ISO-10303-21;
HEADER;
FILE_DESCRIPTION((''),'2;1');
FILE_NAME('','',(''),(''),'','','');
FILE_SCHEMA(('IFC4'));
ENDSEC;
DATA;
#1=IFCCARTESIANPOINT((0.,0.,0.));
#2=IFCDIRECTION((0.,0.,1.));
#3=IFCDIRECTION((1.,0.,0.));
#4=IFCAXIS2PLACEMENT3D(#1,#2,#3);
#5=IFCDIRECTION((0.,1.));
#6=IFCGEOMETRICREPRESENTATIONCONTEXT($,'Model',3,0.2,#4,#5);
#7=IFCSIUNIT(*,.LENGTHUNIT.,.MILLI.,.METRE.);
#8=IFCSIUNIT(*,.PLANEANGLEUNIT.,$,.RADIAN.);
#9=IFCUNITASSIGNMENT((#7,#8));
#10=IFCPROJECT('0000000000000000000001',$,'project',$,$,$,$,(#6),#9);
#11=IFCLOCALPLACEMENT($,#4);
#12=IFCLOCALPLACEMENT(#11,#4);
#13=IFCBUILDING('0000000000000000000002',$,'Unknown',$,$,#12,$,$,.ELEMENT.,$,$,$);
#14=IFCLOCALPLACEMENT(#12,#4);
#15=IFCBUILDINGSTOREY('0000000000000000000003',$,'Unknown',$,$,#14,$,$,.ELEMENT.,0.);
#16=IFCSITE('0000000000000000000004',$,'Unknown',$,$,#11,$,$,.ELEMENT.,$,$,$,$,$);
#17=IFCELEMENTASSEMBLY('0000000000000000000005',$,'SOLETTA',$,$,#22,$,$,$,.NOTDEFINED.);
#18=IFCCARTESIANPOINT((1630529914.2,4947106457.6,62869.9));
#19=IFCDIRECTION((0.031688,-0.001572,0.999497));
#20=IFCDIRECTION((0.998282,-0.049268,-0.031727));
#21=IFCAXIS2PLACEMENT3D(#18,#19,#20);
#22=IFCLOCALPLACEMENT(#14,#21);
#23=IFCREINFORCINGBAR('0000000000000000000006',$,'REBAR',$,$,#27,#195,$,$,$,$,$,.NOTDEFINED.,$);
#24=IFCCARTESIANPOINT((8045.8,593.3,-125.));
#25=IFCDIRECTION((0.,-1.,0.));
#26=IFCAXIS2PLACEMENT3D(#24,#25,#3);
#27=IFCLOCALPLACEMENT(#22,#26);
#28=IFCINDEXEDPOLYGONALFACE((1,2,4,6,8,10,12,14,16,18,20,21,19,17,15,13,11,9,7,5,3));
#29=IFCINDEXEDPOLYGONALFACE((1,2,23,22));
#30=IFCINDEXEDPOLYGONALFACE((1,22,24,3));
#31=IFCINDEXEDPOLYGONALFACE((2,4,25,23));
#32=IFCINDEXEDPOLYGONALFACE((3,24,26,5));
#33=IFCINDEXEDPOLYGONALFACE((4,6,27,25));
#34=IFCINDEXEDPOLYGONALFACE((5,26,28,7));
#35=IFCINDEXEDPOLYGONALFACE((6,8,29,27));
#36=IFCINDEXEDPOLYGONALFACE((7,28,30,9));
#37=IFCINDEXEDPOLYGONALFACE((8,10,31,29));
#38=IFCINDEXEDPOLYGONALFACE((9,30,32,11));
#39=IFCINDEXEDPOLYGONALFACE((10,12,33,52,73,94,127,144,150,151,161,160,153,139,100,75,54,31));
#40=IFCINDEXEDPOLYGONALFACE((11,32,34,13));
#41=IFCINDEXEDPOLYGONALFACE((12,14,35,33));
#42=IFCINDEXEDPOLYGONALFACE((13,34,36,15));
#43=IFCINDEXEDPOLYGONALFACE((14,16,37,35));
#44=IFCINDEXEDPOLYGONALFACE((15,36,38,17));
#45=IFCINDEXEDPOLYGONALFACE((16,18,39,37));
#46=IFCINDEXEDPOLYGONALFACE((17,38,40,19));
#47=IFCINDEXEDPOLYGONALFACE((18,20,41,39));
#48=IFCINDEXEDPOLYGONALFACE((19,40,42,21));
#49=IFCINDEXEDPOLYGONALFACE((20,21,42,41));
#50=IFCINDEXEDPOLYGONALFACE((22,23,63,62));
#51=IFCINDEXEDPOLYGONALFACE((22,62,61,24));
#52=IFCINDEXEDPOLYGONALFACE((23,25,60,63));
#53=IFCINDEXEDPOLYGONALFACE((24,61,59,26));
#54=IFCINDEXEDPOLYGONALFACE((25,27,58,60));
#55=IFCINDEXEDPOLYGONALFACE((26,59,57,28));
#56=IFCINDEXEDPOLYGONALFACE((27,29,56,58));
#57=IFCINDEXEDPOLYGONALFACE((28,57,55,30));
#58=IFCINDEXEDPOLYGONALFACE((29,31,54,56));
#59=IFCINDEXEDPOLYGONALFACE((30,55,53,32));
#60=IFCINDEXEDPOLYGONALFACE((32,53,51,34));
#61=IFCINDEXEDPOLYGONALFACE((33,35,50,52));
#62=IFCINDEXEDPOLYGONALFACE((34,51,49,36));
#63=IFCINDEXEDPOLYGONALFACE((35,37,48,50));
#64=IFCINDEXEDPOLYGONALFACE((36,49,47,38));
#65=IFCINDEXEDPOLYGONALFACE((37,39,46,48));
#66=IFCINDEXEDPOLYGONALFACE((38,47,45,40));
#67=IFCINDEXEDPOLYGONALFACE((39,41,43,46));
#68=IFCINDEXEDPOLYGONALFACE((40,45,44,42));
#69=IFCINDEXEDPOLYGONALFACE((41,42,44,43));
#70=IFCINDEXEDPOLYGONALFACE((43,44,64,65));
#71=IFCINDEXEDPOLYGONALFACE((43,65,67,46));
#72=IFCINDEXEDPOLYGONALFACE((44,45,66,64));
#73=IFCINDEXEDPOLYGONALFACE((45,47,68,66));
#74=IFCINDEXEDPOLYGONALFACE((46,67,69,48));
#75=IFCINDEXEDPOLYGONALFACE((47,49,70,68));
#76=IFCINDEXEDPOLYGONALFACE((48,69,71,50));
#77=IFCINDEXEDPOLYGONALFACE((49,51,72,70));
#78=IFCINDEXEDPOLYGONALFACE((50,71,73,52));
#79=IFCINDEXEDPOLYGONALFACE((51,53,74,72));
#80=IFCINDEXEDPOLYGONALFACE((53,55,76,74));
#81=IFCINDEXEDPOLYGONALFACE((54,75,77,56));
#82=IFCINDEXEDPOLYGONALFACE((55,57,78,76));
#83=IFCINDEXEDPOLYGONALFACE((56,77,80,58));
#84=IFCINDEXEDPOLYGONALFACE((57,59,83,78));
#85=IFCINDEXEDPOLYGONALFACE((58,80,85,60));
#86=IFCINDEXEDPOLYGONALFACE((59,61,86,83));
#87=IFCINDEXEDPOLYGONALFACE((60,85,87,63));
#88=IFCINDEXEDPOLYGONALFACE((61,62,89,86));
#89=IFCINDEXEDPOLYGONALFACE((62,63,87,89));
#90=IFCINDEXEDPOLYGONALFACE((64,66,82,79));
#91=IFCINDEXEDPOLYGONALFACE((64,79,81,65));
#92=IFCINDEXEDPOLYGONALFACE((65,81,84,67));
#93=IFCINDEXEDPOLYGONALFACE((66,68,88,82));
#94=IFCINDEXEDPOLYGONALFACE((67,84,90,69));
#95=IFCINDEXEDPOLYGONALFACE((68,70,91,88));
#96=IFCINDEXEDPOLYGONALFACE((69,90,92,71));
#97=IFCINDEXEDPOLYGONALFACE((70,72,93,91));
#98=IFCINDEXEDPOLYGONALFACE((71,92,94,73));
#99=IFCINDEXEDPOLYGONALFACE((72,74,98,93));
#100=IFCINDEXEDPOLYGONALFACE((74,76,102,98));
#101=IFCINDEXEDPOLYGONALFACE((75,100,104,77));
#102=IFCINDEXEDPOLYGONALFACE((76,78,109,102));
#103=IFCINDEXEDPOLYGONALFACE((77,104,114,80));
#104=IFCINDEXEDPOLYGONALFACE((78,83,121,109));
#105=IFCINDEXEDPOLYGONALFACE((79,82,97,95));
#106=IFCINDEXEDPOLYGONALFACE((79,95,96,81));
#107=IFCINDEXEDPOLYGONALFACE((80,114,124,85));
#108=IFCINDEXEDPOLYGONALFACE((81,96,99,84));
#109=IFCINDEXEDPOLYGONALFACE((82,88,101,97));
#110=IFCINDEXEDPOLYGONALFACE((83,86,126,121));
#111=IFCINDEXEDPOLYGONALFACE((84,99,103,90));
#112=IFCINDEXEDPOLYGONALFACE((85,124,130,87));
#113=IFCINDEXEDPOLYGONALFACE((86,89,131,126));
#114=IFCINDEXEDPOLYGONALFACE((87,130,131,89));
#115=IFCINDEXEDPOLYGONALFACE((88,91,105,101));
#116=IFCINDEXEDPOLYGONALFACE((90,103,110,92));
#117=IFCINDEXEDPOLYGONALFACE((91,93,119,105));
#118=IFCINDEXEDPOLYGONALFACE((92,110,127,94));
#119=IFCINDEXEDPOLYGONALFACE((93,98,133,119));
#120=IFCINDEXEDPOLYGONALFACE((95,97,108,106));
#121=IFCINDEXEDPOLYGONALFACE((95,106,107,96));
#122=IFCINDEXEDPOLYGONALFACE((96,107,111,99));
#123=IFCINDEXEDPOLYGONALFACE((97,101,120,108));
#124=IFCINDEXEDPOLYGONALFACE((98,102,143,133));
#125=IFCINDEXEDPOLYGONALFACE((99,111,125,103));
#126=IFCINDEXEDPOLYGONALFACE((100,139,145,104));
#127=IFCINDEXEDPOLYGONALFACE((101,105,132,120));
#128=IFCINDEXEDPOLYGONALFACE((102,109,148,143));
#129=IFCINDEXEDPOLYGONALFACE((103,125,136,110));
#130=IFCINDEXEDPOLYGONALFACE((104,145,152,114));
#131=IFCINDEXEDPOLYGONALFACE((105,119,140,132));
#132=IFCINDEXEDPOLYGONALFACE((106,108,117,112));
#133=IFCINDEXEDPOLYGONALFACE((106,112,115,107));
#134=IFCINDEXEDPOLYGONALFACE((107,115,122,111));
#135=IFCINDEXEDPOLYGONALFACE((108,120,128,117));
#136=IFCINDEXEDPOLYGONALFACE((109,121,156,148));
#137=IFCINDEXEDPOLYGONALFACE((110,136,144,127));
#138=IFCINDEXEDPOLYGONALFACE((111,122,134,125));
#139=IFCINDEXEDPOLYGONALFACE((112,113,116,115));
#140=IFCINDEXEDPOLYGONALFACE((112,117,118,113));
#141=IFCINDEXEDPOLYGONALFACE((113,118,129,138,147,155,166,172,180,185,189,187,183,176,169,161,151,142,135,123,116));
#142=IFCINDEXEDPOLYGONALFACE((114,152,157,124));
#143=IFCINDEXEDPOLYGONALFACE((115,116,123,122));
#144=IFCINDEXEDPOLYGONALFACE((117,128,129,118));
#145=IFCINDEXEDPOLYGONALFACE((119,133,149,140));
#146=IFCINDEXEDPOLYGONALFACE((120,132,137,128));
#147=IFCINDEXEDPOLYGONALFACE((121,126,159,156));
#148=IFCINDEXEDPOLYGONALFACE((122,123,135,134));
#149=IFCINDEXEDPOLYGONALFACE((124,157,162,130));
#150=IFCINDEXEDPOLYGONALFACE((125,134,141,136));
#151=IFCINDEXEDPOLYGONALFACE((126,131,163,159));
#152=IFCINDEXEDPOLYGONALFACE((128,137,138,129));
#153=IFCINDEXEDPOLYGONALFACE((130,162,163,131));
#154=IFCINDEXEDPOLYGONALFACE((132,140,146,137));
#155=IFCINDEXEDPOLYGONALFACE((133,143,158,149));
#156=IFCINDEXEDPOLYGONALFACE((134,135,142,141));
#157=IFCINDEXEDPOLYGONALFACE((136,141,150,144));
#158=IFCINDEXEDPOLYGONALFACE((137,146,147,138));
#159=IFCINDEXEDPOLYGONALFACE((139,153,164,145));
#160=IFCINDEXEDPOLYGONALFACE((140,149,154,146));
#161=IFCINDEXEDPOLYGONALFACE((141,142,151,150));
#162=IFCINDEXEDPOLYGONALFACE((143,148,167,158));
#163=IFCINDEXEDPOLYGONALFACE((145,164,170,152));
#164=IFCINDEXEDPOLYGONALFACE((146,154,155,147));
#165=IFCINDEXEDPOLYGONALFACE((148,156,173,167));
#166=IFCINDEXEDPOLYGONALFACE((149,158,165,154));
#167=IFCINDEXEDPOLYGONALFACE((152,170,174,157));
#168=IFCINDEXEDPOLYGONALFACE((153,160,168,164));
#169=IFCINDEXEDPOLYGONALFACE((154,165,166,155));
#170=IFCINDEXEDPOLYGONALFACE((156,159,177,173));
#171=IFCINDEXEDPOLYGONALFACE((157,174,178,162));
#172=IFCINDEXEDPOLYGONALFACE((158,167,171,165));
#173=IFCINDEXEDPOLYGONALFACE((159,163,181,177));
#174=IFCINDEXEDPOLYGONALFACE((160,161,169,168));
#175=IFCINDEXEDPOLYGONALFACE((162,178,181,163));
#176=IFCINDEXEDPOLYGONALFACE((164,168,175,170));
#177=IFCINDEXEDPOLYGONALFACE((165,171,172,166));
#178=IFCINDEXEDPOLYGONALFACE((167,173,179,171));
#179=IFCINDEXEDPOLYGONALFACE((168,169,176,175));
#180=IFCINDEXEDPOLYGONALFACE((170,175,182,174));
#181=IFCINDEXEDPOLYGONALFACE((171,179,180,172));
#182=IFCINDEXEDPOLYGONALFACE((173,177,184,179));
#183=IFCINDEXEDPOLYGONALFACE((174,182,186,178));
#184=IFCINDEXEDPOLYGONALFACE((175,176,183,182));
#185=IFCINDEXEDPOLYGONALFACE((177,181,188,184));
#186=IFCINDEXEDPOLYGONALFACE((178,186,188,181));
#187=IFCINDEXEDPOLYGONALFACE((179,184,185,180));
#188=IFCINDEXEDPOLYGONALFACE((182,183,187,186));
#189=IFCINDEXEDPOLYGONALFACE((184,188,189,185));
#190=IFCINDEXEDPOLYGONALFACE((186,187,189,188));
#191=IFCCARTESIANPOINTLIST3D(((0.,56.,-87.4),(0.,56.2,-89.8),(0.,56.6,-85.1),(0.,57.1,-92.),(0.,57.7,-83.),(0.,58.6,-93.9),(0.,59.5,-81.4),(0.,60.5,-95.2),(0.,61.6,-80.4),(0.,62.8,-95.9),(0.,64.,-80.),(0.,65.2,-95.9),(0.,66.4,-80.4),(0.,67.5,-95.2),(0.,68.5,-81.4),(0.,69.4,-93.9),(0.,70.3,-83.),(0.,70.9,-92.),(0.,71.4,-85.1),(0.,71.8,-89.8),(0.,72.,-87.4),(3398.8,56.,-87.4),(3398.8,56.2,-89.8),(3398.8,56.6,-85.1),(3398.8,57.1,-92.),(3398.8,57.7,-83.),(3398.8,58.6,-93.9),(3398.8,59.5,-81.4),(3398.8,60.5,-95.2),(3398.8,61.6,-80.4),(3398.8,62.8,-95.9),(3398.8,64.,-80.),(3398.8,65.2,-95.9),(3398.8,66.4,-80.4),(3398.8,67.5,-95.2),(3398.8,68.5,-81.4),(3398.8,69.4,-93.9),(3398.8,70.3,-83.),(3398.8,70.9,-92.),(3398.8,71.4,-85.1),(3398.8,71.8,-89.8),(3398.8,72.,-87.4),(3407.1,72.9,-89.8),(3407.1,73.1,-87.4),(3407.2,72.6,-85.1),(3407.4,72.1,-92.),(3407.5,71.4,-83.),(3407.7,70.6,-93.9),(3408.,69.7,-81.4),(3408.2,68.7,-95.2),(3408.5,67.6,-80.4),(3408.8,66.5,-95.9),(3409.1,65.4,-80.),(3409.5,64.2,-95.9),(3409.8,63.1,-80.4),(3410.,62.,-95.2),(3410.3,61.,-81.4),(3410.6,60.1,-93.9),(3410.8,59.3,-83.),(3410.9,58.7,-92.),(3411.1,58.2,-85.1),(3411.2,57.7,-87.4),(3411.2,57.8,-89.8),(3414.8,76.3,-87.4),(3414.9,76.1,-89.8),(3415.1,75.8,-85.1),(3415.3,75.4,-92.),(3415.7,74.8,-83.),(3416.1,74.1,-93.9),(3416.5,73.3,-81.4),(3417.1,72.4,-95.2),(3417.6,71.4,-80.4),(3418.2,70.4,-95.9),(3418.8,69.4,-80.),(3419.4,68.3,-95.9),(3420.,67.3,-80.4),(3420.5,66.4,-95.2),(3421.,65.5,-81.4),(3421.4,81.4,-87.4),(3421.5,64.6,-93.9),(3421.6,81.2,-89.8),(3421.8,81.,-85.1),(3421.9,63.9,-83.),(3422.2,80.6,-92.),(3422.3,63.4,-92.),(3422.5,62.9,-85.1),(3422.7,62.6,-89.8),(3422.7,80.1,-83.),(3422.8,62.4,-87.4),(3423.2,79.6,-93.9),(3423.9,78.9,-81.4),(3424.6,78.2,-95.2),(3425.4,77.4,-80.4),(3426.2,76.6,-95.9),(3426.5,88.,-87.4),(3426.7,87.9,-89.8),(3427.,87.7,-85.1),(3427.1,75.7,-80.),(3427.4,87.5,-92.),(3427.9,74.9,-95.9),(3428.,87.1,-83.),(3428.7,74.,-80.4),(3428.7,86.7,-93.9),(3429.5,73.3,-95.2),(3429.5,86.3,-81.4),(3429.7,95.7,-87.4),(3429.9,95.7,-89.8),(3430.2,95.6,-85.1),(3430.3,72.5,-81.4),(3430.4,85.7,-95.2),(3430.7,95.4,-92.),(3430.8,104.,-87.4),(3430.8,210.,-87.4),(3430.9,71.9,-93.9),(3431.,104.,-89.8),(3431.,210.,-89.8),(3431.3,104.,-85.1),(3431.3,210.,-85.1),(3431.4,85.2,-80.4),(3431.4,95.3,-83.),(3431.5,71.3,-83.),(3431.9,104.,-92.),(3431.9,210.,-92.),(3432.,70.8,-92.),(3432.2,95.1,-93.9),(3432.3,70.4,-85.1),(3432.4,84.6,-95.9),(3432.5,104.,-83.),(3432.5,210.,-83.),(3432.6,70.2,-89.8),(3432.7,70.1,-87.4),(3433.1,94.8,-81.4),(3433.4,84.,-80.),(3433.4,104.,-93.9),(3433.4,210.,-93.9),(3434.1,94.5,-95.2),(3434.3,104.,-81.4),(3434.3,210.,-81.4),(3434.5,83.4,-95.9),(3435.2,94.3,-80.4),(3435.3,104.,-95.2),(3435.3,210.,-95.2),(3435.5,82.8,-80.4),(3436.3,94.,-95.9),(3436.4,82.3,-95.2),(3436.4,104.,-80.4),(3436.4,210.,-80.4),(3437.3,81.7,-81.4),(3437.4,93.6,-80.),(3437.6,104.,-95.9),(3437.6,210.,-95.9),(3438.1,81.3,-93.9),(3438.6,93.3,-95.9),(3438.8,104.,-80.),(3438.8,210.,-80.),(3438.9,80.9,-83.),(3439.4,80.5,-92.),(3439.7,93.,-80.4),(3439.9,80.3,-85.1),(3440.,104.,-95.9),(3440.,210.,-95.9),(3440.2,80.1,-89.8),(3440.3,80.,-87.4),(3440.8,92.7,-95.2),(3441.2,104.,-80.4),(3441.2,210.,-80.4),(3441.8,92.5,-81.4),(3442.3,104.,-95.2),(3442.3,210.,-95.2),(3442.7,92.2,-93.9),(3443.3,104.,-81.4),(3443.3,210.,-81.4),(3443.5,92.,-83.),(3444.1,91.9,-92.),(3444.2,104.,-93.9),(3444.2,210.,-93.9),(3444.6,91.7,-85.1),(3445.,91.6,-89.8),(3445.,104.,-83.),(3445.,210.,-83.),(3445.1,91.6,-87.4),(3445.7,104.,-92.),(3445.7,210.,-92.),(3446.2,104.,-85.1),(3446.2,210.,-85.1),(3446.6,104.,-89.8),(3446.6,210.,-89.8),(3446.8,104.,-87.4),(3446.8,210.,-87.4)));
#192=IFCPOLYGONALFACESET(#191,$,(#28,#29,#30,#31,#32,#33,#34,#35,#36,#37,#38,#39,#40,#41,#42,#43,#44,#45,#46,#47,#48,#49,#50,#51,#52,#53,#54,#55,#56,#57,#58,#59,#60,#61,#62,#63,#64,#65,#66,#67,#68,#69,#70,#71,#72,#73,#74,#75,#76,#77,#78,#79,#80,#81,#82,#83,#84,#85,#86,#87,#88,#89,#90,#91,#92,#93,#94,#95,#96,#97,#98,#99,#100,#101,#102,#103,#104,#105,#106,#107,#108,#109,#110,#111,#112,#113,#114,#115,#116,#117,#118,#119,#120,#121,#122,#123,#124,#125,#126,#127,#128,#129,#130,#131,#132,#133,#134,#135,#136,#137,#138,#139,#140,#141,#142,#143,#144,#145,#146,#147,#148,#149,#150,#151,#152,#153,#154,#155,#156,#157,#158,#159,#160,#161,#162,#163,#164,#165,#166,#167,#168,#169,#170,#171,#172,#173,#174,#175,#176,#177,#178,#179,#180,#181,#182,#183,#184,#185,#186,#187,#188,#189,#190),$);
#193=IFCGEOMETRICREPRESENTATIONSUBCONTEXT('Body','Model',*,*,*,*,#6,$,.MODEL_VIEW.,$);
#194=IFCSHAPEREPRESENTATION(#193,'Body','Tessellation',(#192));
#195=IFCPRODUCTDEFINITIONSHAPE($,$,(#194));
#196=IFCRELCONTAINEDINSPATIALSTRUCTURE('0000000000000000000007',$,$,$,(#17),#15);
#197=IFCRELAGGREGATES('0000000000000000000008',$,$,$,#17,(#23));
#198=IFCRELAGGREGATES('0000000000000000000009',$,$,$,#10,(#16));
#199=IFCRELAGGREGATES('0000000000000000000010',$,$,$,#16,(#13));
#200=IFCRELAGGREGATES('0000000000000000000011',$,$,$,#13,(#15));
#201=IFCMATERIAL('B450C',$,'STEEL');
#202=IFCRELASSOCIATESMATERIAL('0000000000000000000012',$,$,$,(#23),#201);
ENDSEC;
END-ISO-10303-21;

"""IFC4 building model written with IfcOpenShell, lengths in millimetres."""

from ifc_helpers import new_model, entity, si_unit, direction, frame, origin_with_axes, place, context, subcontext, project, spatial, material, element, aggregate, save


model = new_model("IFC4")

# Units and contexts
model_context = context("Model", 3, precision=0.2, world=origin_with_axes(), true_north=direction((0.0, 1.0)))
body_context = subcontext(model_context, "Body", "Model", "MODEL_VIEW")
ifc_project = project(units=[si_unit("LENGTHUNIT", "METRE", prefix="MILLI"), si_unit("PLANEANGLEUNIT", "RADIAN")], contexts=[model_context])

# Site, building, storey
site_placement = place(None, origin_with_axes())
site = spatial("IfcSite", under=ifc_project, at=site_placement, Name="Unknown", CompositionType="ELEMENT")
building_placement = place(site_placement, origin_with_axes())
building = spatial("IfcBuilding", under=site, at=building_placement, Name="Unknown", CompositionType="ELEMENT")
storey_placement = place(building_placement, origin_with_axes())
storey = spatial("IfcBuildingStorey", under=building, at=storey_placement, Name="Unknown", CompositionType="ELEMENT", Elevation=0.0)

# Element assembly, reinforcing bar
ifc_material = material(Name="B450C", Category="STEEL")
assembly_1_placement = place(storey_placement, frame((1630529914.2, 4947106457.6, 62869.9), z_axis=(0.031688, -0.001572, 0.999497), x_axis=(0.998282, -0.049268, -0.031727)))
assembly_1 = element("IfcElementAssembly", 1, at=assembly_1_placement, inside=storey, Name="SOLETTA", PredefinedType="NOTDEFINED")
reinforcing_bar_1_placement = place(assembly_1_placement, frame((8045.8, 593.3, -125.0), z_axis=(0.0, -1.0, 0.0), x_axis=(1.0, 0.0, 0.0)))
reinforcing_bar_1 = element("IfcReinforcingBar", 2, at=reinforcing_bar_1_placement, material=ifc_material, Name="REBAR", PredefinedType="NOTDEFINED", context=body_context, shape_type="AdvancedSweptSolid", body=[
    entity("IfcSweptDiskSolid", entity("IfcIndexedPolyCurve", entity("IfcCartesianPointList3D", [[0.0, 64.0, -88.0], [3398.8, 64.0, -88.0], [3427.1, 75.7, -88.0], [3438.8, 104.0, -88.0], [3438.8, 210.0, -88.0]]), [entity("IfcLineIndex", [1, 2]), entity("IfcArcIndex", [2, 3, 4]), entity("IfcLineIndex", [4, 5])]), 8.0),
])
aggregate(assembly_1, [reinforcing_bar_1])

save(model, "model.ifc")
